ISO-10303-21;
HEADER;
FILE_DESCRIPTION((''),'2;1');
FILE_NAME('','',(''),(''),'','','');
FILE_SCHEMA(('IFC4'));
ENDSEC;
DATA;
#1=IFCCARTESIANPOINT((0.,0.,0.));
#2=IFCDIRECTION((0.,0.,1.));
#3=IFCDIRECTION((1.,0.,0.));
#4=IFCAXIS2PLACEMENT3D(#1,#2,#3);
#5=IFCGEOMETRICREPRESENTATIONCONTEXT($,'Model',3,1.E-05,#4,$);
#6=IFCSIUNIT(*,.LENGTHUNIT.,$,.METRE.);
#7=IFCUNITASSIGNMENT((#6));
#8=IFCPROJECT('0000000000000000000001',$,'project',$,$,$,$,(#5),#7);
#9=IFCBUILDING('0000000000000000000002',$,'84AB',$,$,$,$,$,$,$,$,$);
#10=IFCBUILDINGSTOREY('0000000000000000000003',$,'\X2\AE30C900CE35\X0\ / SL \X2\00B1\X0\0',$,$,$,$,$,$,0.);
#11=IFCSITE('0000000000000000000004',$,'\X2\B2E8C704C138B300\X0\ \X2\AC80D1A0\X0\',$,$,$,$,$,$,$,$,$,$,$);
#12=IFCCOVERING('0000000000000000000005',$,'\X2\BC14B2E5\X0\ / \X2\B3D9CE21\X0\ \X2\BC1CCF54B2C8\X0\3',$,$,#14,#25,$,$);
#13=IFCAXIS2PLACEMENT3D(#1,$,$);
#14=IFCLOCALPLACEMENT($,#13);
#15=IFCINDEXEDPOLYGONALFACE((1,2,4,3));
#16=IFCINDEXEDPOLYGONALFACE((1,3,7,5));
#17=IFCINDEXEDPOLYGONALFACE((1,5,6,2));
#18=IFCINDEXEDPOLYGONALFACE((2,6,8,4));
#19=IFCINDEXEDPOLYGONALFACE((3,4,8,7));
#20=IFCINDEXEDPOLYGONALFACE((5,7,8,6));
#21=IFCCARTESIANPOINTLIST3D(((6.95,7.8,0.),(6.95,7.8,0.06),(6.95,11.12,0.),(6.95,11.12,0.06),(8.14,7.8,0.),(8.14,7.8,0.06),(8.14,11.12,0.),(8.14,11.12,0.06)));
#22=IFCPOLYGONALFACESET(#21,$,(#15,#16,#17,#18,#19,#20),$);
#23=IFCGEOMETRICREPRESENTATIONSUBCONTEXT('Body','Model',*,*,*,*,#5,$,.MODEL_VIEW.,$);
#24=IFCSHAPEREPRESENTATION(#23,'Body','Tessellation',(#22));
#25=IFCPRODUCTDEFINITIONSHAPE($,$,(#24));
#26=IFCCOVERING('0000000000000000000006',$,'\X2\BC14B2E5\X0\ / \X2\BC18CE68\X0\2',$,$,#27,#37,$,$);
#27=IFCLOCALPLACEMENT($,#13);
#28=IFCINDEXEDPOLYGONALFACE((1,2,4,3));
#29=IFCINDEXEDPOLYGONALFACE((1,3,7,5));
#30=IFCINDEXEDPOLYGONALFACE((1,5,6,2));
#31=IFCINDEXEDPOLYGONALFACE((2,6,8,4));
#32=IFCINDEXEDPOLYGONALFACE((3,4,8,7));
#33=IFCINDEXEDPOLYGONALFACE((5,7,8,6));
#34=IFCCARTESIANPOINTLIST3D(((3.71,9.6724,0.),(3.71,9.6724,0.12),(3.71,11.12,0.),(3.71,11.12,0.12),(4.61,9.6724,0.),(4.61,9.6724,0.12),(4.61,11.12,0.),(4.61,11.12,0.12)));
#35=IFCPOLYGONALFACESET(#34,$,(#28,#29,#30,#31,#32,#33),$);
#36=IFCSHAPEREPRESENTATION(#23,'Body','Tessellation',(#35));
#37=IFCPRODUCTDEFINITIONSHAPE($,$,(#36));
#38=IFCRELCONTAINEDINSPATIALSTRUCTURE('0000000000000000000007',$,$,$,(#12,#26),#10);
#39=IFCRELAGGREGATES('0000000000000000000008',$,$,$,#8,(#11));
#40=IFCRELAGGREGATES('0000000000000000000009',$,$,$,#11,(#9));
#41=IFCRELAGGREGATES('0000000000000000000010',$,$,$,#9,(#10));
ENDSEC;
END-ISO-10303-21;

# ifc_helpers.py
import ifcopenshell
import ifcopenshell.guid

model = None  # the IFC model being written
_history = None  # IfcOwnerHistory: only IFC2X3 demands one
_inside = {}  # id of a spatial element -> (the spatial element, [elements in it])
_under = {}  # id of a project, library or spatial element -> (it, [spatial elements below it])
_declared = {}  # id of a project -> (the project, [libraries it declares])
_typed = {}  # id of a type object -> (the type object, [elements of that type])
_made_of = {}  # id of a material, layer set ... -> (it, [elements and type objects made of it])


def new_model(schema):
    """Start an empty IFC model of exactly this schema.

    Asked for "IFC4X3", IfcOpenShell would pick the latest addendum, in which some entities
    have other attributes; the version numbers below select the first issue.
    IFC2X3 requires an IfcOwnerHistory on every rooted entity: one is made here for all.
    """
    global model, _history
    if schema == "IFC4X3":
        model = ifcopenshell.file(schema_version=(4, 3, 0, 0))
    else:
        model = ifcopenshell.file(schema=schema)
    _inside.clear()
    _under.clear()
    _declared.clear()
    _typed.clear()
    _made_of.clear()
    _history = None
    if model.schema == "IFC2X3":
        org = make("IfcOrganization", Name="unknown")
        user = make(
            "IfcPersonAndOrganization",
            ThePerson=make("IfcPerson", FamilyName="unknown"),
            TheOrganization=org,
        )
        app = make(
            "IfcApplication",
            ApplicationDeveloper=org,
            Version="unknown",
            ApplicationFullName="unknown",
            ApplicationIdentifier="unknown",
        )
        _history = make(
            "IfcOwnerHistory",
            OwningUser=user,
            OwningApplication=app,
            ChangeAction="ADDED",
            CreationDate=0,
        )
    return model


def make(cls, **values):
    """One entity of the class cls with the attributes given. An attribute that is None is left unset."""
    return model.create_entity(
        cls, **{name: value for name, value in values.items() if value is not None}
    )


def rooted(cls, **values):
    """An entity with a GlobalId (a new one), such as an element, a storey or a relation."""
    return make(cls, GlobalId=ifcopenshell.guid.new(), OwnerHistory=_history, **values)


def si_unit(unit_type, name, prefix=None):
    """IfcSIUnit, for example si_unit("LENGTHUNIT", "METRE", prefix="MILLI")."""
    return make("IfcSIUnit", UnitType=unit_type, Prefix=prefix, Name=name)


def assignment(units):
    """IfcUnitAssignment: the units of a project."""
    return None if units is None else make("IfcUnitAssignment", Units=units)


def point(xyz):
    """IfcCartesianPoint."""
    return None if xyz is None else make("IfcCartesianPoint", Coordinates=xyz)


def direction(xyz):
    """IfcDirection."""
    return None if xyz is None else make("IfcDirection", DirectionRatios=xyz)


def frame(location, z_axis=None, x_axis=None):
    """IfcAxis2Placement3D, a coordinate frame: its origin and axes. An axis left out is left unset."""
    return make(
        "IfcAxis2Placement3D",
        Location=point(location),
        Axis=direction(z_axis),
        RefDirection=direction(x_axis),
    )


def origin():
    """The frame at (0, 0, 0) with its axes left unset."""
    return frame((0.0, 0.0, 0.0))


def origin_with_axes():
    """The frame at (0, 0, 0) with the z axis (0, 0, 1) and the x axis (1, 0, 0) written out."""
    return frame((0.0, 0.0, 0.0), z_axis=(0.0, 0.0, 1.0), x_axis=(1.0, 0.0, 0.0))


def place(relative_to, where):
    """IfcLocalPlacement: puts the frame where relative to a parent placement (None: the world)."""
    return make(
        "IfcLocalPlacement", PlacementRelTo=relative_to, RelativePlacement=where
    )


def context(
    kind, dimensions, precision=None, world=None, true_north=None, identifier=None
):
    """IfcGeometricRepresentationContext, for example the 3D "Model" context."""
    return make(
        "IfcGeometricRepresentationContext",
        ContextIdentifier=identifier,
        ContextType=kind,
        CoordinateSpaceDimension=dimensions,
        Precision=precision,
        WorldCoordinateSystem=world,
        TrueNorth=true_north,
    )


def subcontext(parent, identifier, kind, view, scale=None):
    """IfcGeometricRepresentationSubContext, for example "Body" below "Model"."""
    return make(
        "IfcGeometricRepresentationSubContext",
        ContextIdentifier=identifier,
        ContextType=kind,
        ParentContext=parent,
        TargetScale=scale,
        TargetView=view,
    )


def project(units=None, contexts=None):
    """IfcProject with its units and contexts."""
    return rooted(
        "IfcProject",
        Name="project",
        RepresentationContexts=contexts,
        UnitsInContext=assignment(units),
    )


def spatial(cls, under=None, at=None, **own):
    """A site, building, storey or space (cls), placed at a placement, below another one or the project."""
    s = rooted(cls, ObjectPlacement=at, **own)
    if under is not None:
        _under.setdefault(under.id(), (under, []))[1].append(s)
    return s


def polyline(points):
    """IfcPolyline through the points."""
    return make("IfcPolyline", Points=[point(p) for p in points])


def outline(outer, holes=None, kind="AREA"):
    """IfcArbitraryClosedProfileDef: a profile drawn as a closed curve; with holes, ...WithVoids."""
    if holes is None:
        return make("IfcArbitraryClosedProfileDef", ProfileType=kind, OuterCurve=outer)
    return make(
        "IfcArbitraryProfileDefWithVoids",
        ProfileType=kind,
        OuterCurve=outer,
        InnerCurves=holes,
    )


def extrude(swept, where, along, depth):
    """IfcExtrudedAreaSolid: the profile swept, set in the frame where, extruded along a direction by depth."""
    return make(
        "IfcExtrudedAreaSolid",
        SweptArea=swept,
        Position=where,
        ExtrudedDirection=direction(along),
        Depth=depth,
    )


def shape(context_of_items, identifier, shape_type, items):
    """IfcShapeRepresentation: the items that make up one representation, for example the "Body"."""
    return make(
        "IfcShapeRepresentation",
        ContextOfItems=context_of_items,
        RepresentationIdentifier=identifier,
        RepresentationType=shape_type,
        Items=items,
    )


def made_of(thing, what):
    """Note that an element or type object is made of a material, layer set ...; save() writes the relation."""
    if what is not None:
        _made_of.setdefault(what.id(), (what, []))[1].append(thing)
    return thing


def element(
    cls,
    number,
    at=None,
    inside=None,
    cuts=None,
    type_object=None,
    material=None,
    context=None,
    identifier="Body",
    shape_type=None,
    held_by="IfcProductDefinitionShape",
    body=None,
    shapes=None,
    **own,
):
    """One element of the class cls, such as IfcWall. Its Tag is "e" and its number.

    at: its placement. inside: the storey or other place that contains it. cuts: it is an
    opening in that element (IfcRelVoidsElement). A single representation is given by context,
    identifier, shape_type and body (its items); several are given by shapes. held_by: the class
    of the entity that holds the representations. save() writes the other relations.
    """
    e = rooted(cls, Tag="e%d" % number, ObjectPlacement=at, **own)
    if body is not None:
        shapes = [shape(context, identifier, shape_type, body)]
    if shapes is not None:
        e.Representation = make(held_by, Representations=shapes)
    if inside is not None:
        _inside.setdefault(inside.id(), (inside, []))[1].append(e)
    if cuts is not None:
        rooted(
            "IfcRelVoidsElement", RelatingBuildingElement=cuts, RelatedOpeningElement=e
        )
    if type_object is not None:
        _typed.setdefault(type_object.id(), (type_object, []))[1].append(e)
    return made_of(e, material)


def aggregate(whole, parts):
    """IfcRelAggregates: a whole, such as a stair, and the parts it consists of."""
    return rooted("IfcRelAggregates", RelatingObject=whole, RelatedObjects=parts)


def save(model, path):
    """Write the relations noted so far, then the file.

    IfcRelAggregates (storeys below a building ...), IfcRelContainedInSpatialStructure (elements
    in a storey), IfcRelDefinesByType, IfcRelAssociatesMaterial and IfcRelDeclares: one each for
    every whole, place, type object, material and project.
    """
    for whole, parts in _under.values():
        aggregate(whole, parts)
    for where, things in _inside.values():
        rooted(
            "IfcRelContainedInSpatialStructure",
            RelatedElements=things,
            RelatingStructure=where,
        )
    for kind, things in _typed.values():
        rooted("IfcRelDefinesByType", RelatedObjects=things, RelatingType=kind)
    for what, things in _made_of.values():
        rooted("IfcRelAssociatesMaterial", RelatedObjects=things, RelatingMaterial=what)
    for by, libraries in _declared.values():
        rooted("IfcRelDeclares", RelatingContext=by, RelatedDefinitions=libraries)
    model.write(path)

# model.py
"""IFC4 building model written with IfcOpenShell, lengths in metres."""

from ifc_helpers import new_model, si_unit, origin, origin_with_axes, place, context, subcontext, project, spatial, polyline, outline, extrude, element, save


model = new_model("IFC4")

# Units and contexts
model_context = context("Model", 3, precision=1e-05, world=origin_with_axes())
body_context = subcontext(model_context, "Body", "Model", "MODEL_VIEW")
ifc_project = project(units=[si_unit("LENGTHUNIT", "METRE")], contexts=[model_context])

# Site, building, storey
site = spatial("IfcSite", under=ifc_project, Name="단위세대 검토")
building = spatial("IfcBuilding", under=site, Name="84AB")
storey = spatial("IfcBuildingStorey", under=building, Name="기준층 / SL ±0", Elevation=0.0)

# Coverings
covering_1_placement = place(None, origin_with_axes())
element("IfcCovering", 1, at=covering_1_placement, inside=storey, Name="바닥 / 동측 발코니3", context=body_context, shape_type="SweptSolid", body=[
    extrude(outline(polyline([(8.14, 7.8), (8.14, 11.12), (6.95, 11.12), (6.95, 7.8), (8.14, 7.8)])), origin(), (0.0, 0.0, 1.0), 0.06),
])
covering_2_placement = place(None, origin_with_axes())
element("IfcCovering", 2, at=covering_2_placement, inside=storey, Name="바닥 / 반침2", context=body_context, shape_type="SweptSolid", body=[
    extrude(outline(polyline([(4.61, 9.6724), (4.61, 11.12), (3.71, 11.12), (3.71, 9.6724), (4.61, 9.6724)])), origin(), (0.0, 0.0, 1.0), 0.12),
])

save(model, "model.ifc")
